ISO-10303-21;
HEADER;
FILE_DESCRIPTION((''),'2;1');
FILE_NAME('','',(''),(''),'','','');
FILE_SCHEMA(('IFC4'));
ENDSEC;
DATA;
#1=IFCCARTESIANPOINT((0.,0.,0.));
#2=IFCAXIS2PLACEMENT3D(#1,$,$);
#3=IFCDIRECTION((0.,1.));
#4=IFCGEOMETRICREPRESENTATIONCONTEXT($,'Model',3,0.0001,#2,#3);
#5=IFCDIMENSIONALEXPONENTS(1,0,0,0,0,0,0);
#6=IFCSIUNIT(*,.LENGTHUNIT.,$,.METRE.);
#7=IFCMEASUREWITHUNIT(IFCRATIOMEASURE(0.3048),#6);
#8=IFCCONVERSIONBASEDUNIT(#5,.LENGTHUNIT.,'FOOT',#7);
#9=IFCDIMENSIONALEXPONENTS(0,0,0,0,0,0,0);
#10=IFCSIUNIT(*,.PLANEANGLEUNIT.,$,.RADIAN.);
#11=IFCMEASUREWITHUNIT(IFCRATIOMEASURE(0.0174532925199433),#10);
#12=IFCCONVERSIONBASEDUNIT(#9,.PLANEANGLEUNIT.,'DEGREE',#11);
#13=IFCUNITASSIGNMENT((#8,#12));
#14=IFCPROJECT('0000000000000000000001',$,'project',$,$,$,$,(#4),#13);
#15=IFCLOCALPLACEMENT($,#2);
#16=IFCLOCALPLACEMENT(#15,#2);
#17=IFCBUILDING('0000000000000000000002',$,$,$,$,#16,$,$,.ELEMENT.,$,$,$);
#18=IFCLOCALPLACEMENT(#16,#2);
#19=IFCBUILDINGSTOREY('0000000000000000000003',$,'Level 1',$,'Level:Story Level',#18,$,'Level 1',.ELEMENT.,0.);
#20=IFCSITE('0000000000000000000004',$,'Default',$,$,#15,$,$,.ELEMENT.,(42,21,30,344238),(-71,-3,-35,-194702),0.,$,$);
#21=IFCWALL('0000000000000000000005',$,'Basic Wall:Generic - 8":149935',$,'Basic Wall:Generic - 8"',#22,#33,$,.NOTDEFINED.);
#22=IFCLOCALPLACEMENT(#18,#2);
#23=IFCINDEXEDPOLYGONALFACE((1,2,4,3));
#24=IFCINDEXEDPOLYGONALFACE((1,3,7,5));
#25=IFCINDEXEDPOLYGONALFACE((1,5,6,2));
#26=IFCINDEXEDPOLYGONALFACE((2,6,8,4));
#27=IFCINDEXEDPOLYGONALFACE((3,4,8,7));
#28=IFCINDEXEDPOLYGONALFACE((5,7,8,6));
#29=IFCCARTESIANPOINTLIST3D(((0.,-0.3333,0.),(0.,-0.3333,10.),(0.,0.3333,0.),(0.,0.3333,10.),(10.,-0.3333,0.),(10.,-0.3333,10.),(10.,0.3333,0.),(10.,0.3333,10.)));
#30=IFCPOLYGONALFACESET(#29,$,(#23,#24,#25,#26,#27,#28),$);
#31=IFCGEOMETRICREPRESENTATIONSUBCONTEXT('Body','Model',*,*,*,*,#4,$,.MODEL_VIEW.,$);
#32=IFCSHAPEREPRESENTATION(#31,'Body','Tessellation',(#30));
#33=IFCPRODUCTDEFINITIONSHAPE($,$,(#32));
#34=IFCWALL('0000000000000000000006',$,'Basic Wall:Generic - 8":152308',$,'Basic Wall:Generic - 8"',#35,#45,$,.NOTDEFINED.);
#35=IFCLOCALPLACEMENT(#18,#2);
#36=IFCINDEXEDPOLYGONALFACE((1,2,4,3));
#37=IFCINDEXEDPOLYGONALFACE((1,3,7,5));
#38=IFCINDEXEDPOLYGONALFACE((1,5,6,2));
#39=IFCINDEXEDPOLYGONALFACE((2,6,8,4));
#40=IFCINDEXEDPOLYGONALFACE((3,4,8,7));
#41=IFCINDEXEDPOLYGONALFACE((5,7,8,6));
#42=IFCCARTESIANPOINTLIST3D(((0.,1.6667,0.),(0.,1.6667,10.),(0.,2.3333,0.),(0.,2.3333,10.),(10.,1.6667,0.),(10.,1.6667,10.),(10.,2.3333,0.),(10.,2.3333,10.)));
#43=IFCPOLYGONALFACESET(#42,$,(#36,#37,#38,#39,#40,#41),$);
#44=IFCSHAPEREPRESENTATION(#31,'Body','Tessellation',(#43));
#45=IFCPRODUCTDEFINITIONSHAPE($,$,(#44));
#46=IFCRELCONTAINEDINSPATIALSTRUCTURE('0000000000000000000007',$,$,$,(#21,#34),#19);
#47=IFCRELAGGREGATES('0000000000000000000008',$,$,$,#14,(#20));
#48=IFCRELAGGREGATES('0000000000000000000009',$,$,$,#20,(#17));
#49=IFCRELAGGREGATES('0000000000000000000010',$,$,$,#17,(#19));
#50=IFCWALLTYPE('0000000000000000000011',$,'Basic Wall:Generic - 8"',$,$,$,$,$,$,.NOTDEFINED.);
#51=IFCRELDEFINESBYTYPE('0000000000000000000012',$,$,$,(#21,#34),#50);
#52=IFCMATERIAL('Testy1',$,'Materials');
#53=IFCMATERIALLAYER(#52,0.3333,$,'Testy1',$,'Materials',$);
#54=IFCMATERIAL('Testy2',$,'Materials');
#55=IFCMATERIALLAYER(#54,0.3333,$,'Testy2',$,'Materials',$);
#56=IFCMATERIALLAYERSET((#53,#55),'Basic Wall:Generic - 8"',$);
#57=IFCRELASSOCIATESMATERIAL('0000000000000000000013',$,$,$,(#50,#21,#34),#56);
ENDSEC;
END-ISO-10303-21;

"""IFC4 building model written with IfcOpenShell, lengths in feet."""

from ifc_helpers import new_model, entity, si_unit, converted_unit, direction, frame, frame_2d, origin, place, context, subcontext, project, spatial, rectangle, extrude, material, layer, layer_set, layer_usage, type_object, element, save


model = new_model("IFC4")

# Units and contexts
model_context = context("Model", 3, precision=0.0001, world=origin(), true_north=direction((0.0, 1.0)))
body_context = subcontext(model_context, "Body", "Model", "MODEL_VIEW")
ifc_project = project(units=[converted_unit("LENGTHUNIT", "FOOT", entity("IfcRatioMeasure", 0.3048), si_unit("LENGTHUNIT", "METRE"), dimensions=[1, 0, 0, 0, 0, 0, 0]), converted_unit("PLANEANGLEUNIT", "DEGREE", entity("IfcRatioMeasure", 0.0174532925199433), si_unit("PLANEANGLEUNIT", "RADIAN"), dimensions=[0, 0, 0, 0, 0, 0, 0])], contexts=[model_context])

# Site, building, storey
site_placement = place(None, origin())
site = spatial("IfcSite", under=ifc_project, at=site_placement, Name="Default", CompositionType="ELEMENT", RefLatitude=(42, 21, 30, 344238), RefLongitude=(-71, -3, -35, -194702), RefElevation=0.0)
building_placement = place(site_placement, origin())
building = spatial("IfcBuilding", under=site, at=building_placement, CompositionType="ELEMENT")
storey_placement = place(building_placement, origin())
storey = spatial("IfcBuildingStorey", under=building, at=storey_placement, Name="Level 1", ObjectType="Level:Story Level", LongName="Level 1", CompositionType="ELEMENT", Elevation=0.0)

# Walls
ifc_material_1 = material(Name="Testy1", Category="Materials")
ifc_layer_1 = layer(ifc_material_1, 0.3333, Name="Testy1", Category="Materials")
ifc_material_2 = material(Name="Testy2", Category="Materials")
ifc_layer_2 = layer(ifc_material_2, 0.3333, Name="Testy2", Category="Materials")
ifc_layer_set = layer_set([ifc_layer_1, ifc_layer_2], Name="Basic Wall:Generic - 8\"")
ifc_layer_usage_1 = layer_usage(ifc_layer_set, "AXIS2", "NEGATIVE", 0.3333)
wall_type = type_object("IfcWallType", Name="Basic Wall:Generic - 8\"", PredefinedType="NOTDEFINED", material=ifc_layer_set)
wall_1_placement = place(storey_placement, origin())
element("IfcWall", 1, at=wall_1_placement, inside=storey, type_object=wall_type, material=ifc_layer_usage_1, Name="Basic Wall:Generic - 8\":149935", ObjectType="Basic Wall:Generic - 8\"", PredefinedType="NOTDEFINED", context=body_context, shape_type="SweptSolid", body=[
    extrude(rectangle(XDim=10.0, YDim=0.6667, at=frame_2d((5.0, 0.0), x_axis=(-1.0, 0.0))), origin(), (0.0, 0.0, 1.0), 10.0),
])
ifc_layer_usage_2 = layer_usage(ifc_layer_set, "AXIS2", "NEGATIVE", 0.3333)
wall_2_placement = place(storey_placement, frame((0.0, 2.0, 0.0)))
element("IfcWall", 2, at=wall_2_placement, inside=storey, type_object=wall_type, material=ifc_layer_usage_2, Name="Basic Wall:Generic - 8\":152308", ObjectType="Basic Wall:Generic - 8\"", PredefinedType="NOTDEFINED", context=body_context, shape_type="SweptSolid", body=[
    extrude(rectangle(XDim=10.0, YDim=0.6667, at=frame_2d((5.0, 0.0), x_axis=(-1.0, 0.0))), origin(), (0.0, 0.0, 1.0), 10.0),
])

save(model, "model.ifc")
